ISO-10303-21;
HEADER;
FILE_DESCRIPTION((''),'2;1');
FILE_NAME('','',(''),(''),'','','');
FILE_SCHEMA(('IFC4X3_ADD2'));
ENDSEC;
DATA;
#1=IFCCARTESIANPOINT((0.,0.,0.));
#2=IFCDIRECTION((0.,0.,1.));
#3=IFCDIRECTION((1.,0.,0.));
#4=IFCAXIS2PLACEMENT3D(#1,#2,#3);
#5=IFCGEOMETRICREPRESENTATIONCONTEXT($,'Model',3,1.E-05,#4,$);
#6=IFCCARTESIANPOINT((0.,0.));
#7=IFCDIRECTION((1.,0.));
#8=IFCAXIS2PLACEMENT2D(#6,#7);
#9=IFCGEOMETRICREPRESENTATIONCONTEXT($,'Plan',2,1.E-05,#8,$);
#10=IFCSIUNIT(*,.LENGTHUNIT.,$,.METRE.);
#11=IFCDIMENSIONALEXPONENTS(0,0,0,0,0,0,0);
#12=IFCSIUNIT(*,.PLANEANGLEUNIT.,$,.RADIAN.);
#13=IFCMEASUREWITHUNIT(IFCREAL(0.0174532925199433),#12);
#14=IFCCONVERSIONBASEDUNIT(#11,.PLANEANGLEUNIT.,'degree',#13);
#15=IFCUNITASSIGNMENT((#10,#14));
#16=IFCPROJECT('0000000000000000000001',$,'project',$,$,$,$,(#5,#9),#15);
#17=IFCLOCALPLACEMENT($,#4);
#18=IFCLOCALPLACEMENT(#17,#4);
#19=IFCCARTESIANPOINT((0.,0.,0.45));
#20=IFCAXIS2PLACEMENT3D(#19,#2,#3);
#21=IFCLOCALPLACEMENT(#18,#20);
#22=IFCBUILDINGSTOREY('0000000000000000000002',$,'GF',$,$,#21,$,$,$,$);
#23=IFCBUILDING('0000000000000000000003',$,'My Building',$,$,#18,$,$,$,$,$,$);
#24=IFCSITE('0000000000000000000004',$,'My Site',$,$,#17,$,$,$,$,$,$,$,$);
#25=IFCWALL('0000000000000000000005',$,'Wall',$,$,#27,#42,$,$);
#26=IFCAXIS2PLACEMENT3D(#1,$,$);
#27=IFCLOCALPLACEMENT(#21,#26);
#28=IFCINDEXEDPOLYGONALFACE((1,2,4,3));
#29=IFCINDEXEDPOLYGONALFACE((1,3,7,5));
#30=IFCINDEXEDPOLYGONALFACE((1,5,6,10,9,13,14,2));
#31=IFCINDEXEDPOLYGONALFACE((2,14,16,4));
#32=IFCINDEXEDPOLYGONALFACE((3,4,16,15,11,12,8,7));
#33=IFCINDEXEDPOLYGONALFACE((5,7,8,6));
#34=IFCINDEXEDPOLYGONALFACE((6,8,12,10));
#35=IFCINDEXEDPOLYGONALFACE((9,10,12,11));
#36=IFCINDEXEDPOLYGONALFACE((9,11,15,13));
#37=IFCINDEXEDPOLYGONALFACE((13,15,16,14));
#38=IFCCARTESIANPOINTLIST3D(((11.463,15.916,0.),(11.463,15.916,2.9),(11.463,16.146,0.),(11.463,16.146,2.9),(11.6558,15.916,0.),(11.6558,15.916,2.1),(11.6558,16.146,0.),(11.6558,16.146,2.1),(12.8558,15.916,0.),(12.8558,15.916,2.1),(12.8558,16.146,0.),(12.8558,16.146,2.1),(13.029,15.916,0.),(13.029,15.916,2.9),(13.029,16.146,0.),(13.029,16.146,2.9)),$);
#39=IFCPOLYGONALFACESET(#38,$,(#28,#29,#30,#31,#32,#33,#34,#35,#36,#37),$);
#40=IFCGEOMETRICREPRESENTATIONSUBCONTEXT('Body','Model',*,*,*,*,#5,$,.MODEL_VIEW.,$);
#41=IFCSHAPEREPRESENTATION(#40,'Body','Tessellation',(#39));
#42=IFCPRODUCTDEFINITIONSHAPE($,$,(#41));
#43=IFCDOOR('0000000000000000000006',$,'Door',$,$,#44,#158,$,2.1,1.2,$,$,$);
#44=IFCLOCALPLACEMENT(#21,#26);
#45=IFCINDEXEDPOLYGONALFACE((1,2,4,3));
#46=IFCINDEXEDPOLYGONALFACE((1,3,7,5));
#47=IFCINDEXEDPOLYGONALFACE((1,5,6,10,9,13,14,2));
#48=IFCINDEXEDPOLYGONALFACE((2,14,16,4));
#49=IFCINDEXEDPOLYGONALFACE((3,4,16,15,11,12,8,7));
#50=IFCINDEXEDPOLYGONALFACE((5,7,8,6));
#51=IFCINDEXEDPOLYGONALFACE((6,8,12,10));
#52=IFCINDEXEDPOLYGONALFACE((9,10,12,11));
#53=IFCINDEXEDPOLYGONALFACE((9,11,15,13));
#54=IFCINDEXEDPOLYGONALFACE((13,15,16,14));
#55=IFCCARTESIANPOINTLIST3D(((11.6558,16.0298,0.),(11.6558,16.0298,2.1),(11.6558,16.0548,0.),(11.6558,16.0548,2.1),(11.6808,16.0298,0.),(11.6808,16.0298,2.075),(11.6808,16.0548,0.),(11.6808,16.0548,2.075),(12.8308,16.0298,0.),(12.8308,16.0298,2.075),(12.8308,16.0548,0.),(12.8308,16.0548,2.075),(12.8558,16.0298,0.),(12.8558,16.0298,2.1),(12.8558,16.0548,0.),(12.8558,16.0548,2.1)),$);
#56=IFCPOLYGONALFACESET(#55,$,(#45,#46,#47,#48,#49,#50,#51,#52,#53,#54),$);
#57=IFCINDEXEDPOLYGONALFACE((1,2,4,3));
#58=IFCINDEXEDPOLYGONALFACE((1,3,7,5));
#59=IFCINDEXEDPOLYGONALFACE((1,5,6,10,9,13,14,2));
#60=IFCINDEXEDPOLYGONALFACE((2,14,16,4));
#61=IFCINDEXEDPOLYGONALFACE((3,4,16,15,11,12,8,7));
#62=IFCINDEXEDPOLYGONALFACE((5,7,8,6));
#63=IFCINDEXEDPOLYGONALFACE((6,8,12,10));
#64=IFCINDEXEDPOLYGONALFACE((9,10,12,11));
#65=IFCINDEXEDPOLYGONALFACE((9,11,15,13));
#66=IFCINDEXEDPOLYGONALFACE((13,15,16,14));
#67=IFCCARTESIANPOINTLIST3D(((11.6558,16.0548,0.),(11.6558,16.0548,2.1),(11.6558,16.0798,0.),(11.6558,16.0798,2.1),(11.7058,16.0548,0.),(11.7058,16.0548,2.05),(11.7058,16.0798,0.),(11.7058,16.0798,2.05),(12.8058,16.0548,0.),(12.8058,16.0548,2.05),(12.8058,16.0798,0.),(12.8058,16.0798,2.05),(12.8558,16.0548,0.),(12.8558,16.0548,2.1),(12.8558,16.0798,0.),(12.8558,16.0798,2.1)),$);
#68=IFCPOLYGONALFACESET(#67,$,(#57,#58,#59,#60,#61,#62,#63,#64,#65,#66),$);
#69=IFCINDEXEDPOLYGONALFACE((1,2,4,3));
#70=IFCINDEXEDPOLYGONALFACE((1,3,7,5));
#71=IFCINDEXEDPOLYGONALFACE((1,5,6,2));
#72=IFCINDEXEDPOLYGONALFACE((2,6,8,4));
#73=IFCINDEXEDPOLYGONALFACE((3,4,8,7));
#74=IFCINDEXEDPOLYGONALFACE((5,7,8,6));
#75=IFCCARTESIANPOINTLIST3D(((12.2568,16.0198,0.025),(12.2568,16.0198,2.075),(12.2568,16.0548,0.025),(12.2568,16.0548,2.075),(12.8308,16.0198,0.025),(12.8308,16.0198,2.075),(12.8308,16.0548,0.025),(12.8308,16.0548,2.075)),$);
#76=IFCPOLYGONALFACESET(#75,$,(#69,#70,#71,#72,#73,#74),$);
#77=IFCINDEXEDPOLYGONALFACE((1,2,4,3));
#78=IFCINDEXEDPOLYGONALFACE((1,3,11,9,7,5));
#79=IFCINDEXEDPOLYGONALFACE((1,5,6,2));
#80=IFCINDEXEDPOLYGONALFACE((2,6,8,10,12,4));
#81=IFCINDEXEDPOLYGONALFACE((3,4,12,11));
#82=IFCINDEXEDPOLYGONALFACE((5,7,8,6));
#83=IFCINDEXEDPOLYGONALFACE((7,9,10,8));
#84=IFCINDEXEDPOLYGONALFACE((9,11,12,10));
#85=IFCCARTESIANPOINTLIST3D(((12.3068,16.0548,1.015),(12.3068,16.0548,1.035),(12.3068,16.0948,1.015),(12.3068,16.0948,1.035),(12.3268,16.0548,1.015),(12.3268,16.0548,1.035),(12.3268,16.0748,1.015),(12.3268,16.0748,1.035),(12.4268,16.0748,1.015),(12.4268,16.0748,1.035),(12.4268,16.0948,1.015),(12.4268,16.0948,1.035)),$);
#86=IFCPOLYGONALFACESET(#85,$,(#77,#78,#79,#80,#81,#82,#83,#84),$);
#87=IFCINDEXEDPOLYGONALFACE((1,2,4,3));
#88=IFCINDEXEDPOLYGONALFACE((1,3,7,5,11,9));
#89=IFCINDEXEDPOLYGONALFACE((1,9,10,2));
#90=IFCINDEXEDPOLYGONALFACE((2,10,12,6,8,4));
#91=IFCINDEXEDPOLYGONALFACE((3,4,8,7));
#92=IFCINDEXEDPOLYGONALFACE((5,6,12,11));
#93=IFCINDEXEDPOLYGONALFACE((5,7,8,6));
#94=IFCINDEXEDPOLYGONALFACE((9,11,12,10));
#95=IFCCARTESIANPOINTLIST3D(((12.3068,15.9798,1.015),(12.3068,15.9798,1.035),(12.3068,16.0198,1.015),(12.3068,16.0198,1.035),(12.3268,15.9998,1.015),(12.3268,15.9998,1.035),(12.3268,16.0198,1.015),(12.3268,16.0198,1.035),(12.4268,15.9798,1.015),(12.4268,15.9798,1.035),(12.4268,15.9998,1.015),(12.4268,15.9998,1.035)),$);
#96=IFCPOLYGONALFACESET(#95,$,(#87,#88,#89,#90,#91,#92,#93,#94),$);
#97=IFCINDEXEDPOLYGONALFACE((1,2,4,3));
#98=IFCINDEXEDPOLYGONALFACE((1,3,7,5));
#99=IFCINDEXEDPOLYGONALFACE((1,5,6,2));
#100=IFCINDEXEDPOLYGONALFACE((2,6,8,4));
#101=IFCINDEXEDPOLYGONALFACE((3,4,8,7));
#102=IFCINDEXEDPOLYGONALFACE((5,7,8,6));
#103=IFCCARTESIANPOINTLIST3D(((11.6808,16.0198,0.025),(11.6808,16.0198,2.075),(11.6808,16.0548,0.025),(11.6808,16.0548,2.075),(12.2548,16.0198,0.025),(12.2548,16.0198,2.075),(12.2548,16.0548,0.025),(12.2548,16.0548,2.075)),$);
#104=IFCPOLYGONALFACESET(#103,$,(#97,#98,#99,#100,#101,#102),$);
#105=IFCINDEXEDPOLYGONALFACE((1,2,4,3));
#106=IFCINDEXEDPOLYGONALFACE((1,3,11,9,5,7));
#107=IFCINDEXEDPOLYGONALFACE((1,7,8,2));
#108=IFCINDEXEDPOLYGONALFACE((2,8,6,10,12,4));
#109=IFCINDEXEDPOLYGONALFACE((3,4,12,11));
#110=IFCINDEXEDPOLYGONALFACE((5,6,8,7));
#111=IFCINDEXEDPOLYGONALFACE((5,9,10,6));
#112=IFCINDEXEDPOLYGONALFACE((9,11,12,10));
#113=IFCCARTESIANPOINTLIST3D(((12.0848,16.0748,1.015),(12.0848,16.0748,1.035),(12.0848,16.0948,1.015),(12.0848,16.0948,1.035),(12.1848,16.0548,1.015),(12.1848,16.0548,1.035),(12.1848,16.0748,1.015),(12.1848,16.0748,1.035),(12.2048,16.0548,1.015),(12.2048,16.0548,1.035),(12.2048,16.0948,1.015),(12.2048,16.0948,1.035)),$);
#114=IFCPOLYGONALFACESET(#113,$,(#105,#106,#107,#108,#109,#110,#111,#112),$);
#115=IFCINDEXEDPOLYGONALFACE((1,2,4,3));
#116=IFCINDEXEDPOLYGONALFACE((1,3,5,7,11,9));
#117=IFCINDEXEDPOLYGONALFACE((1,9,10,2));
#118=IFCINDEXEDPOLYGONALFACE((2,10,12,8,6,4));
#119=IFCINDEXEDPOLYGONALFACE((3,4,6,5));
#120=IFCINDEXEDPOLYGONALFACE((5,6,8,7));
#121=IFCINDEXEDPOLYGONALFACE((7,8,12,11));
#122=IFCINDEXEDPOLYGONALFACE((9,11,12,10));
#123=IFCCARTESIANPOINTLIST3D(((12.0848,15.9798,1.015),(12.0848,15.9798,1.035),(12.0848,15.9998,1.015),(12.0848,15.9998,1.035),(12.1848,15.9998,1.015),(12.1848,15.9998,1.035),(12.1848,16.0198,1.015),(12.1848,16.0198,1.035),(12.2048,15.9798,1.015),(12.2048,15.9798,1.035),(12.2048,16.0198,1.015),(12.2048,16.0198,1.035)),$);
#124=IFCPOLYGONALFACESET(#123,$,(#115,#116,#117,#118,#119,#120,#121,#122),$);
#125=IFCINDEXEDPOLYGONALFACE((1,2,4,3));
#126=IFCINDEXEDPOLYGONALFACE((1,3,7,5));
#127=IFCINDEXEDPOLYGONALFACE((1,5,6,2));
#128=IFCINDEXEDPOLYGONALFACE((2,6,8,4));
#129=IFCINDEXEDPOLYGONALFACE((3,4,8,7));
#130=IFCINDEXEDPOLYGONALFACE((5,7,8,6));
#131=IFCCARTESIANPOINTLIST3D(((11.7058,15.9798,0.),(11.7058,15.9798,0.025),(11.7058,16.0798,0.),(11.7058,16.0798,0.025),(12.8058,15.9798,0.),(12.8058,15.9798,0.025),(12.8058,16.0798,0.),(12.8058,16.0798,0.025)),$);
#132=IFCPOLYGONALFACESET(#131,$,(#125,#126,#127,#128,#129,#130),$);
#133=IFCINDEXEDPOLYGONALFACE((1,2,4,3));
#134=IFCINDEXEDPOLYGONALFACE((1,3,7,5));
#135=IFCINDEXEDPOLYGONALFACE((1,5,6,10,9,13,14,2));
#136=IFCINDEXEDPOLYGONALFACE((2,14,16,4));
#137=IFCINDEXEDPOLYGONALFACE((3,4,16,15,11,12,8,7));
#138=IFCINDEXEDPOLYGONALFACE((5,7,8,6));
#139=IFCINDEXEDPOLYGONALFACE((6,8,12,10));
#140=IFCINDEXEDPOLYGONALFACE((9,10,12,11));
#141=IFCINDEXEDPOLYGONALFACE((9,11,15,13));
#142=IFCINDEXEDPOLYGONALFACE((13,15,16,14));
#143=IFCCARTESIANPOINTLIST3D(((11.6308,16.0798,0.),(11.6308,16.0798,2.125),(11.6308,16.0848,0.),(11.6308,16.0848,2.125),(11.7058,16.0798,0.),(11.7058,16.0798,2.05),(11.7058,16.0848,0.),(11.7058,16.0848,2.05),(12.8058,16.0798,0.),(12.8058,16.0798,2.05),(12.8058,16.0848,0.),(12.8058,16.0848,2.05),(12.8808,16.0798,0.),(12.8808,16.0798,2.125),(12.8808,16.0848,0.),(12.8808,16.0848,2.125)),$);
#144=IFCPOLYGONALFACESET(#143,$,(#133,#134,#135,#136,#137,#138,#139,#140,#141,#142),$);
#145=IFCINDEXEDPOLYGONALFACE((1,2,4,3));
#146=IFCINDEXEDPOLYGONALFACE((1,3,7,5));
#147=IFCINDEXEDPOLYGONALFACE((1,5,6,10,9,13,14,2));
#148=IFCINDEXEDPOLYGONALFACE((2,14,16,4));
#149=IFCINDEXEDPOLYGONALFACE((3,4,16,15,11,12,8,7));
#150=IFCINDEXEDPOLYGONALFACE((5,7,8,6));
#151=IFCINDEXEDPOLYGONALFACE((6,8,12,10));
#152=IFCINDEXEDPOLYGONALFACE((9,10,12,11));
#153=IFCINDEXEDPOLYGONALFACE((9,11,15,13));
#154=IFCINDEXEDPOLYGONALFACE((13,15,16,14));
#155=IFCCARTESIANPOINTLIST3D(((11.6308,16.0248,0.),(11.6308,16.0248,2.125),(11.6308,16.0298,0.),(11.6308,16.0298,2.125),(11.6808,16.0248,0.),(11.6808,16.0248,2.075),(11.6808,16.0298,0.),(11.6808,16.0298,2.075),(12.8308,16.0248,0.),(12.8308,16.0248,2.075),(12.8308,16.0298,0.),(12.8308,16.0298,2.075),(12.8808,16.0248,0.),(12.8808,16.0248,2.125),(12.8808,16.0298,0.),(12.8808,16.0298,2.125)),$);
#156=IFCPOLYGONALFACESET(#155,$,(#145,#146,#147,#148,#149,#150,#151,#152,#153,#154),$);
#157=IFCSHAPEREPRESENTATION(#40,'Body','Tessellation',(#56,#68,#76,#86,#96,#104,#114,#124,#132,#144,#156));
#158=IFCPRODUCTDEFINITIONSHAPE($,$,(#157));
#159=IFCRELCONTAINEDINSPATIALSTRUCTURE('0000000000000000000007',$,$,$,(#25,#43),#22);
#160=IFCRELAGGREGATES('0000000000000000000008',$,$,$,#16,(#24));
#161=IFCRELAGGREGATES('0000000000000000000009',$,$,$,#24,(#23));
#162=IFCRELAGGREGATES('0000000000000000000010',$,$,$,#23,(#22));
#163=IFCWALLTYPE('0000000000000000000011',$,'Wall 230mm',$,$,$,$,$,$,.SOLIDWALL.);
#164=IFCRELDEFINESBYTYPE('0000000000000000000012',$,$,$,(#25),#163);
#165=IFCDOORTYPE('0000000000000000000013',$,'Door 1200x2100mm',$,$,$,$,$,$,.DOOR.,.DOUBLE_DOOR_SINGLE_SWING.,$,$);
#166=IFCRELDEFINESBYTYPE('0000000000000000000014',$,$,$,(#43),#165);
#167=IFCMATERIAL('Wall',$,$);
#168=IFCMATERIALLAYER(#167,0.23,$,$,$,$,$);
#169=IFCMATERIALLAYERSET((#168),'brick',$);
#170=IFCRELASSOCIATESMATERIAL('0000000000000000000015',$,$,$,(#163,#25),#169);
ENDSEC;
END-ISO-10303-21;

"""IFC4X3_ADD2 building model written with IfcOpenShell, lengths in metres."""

from ifc_helpers import new_model, entity, si_unit, converted_unit, frame, origin_with_axes, origin_2d_with_axis, place, context, subcontext, project, spatial, line, indexed_curve, outline, extrude, shape, source, transform, mapped, material, layer, layer_set, layer_usage, type_object, type_shapes, element, fill, save


model = new_model("IFC4X3_ADD2")

# Units and contexts
model_context = context("Model", 3, precision=1e-05, world=origin_with_axes())
plan_context = context("Plan", 2, precision=1e-05, world=origin_2d_with_axis())
body_context_1 = subcontext(model_context, "Body", "Model", "MODEL_VIEW")
body_context_2 = subcontext(plan_context, "Body", "Plan", "PLAN_VIEW")
ifc_project = project(units=[si_unit("LENGTHUNIT", "METRE"), converted_unit("PLANEANGLEUNIT", "degree", entity("IfcReal", 0.0174532925199433), si_unit("PLANEANGLEUNIT", "RADIAN"), dimensions=[0, 0, 0, 0, 0, 0, 0])], contexts=[model_context, plan_context])

# Site, building, storey
site_placement = place(None, origin_with_axes())
site = spatial("IfcSite", under=ifc_project, at=site_placement, Name="My Site")
building_placement = place(site_placement, origin_with_axes())
building = spatial("IfcBuilding", under=site, at=building_placement, Name="My Building")
storey_placement = place(building_placement, frame((0.0, 0.0, 0.45), z_axis=(0.0, 0.0, 1.0), x_axis=(1.0, 0.0, 0.0)))
storey = spatial("IfcBuildingStorey", under=building, at=storey_placement, Name="GF")

# Shared definitions
ifc_material_1 = material(Name="Wall")
ifc_layer = layer(ifc_material_1, 0.23)
ifc_layer_set = layer_set([ifc_layer], Name="brick")
wall_type = type_object("IfcWallType", Name="Wall 230mm", PredefinedType="SOLIDWALL", material=ifc_layer_set)

# Shared definitions
shared_shape_1 = source(origin_with_axes(), body_context_1, "Body", "SweptSolid", [
    extrude(outline(indexed_curve([(0.0, 0.0), (1.2, 0.0), (1.2, 2.1), (0.0, 2.1)], segments=[line(1, 2, 3, 4, 1)])), frame((0.0, -0.6, 0.0), z_axis=(0.0, -1.0, 0.0), x_axis=(1.0, 0.0, 0.0)), (0.0, 0.0, -1.0), 1.2),
])
door_type_1 = type_object("IfcDoorType", Name="Door 1200x2100mm", OperationType="DOUBLE_DOOR_SINGLE_SWING", PredefinedType="DOOR")
shared_shape_2 = source(origin_with_axes(), body_context_1, "Body", "SweptSolid", [
    extrude(outline(indexed_curve([(0.0, 0.0), (0.0, 2.1), (1.2, 2.1), (1.2, 0.0), (1.175, 0.0), (1.175, 2.075), (0.025, 2.075), (0.025, 0.0)], segments=[line(1, 2, 3, 4, 5, 6, 7, 8, 1)])), frame((0.0, 0.025, 0.0), z_axis=(0.0, -1.0, 0.0), x_axis=(1.0, 0.0, 0.0)), (0.0, 0.0, -1.0), 0.025),
    extrude(outline(indexed_curve([(0.0, 0.0), (0.0, 2.1), (1.2, 2.1), (1.2, 0.0), (1.15, 0.0), (1.15, 2.05), (0.05, 2.05), (0.05, 0.0)], segments=[line(1, 2, 3, 4, 5, 6, 7, 8, 1)])), frame((0.0, 0.0, 0.0), z_axis=(0.0, -1.0, 0.0), x_axis=(1.0, 0.0, 0.0)), (0.0, 0.0, -1.0), 0.025),
    extrude(outline(indexed_curve([(0.0, 0.0), (0.574, 0.0), (0.574, 0.035), (0.0, 0.035)], segments=[line(1, 2, 3, 4, 1)])), frame((0.025, 0.025, 0.025), z_axis=(0.0, 0.0, 1.0), x_axis=(1.0, 0.0, 0.0)), (0.0, 0.0, 1.0), 2.05),
    extrude(outline(indexed_curve([(0.0, 0.0), (0.0, -0.04), (-0.12, -0.04), (-0.12, -0.02), (-0.02, -0.02), (-0.02, 0.0)], segments=[line(1, 2, 3, 4, 5, 6, 1)])), frame((0.549, 0.025, 1.015), z_axis=(0.0, 0.0, 1.0), x_axis=(1.0, 0.0, 0.0)), (0.0, 0.0, 1.0), 0.02),
    extrude(outline(indexed_curve([(0.0, 0.0), (0.0, 0.04), (-0.12, 0.04), (-0.12, 0.02), (-0.02, 0.02), (-0.02, 0.0)], segments=[line(1, 2, 3, 4, 5, 6, 1)])), frame((0.549, 0.06, 1.015), z_axis=(0.0, 0.0, 1.0), x_axis=(1.0, 0.0, 0.0)), (0.0, 0.0, 1.0), 0.02),
    extrude(outline(indexed_curve([(0.0, 0.0), (-0.574, 0.0), (-0.574, 0.035), (0.0, 0.035)], segments=[line(1, 2, 3, 4, 1)])), frame((1.175, 0.025, 0.025), z_axis=(0.0, 0.0, 1.0), x_axis=(1.0, 0.0, 0.0)), (0.0, 0.0, 1.0), 2.05),
    extrude(outline(indexed_curve([(0.0, 0.0), (0.0, -0.04), (0.12, -0.04), (0.12, -0.02), (0.02, -0.02), (0.02, 0.0)], segments=[line(1, 2, 3, 4, 5, 6, 1)])), frame((0.651, 0.025, 1.015), z_axis=(0.0, 0.0, 1.0), x_axis=(1.0, 0.0, 0.0)), (0.0, 0.0, 1.0), 0.02),
    extrude(outline(indexed_curve([(0.0, 0.0), (0.0, 0.04), (0.12, 0.04), (0.12, 0.02), (0.02, 0.02), (0.02, 0.0)], segments=[line(1, 2, 3, 4, 5, 6, 1)])), frame((0.651, 0.06, 1.015), z_axis=(0.0, 0.0, 1.0), x_axis=(1.0, 0.0, 0.0)), (0.0, 0.0, 1.0), 0.02),
    extrude(outline(indexed_curve([(0.0, 0.0), (1.1, 0.0), (1.1, 0.1), (0.0, 0.1)], segments=[line(1, 2, 3, 4, 1)])), frame((0.05, 0.0, 0.0), z_axis=(0.0, 0.0, 1.0), x_axis=(1.0, 0.0, 0.0)), (0.0, 0.0, 1.0), 0.025),
    extrude(outline(indexed_curve([(0.0, 0.0), (0.0, 2.125), (1.25, 2.125), (1.25, 0.0), (1.175, 0.0), (1.175, 2.05), (0.075, 2.05), (0.075, 0.0)], segments=[line(1, 2, 3, 4, 5, 6, 7, 8, 1)])), frame((-0.025, -0.005, 0.0), z_axis=(0.0, -1.0, 0.0), x_axis=(1.0, 0.0, 0.0)), (0.0, 0.0, -1.0), 0.005),
    extrude(outline(indexed_curve([(0.0, 0.0), (0.0, 2.125), (1.25, 2.125), (1.25, 0.0), (1.2, 0.0), (1.2, 2.075), (0.05, 2.075), (0.05, 0.0)], segments=[line(1, 2, 3, 4, 5, 6, 7, 8, 1)])), frame((-0.025, 0.05, 0.0), z_axis=(0.0, -1.0, 0.0), x_axis=(1.0, 0.0, 0.0)), (0.0, 0.0, -1.0), 0.005),
])
shared_shape_3 = source(origin_with_axes(), body_context_2, "Body", "Curve2D", [
    entity("IfcIndexedPolyCurve", entity("IfcCartesianPointList2D", [[0.0, 0.0], [0.0, 0.05], [0.025, 0.05], [0.025, 0.025], [0.05, 0.025], [0.05, 0.0]]), [entity("IfcLineIndex", [1, 2, 3, 4, 5, 6, 1])]),
    entity("IfcIndexedPolyCurve", entity("IfcCartesianPointList2D", [[1.2, 0.0], [1.2, 0.05], [1.175, 0.05], [1.175, 0.025], [1.15, 0.025], [1.15, 0.0]]), [entity("IfcLineIndex", [1, 2, 3, 4, 5, 6, 1])]),
    entity("IfcTrimmedCurve", entity("IfcEllipse", entity("IfcAxis2Placement2D", entity("IfcCartesianPoint", [0.06, 0.05]), entity("IfcDirection", [1.0, 0.0])), 0.54, 0.575), [entity("IfcCartesianPoint", [0.6, 0.05])], [entity("IfcCartesianPoint", [0.06, 0.625])], True, "CARTESIAN"),
    entity("IfcIndexedPolyCurve", entity("IfcCartesianPointList2D", [[0.025, 0.05], [0.06, 0.05], [0.06, 0.625], [0.025, 0.625]]), [entity("IfcLineIndex", [1, 2, 3, 4, 1])]),
    entity("IfcTrimmedCurve", entity("IfcEllipse", entity("IfcAxis2Placement2D", entity("IfcCartesianPoint", [1.14, 0.05]), entity("IfcDirection", [1.0, 0.0])), 0.54, 0.575), [entity("IfcCartesianPoint", [1.14, 0.625])], [entity("IfcCartesianPoint", [0.6, 0.05])], True, "CARTESIAN"),
    entity("IfcIndexedPolyCurve", entity("IfcCartesianPointList2D", [[1.175, 0.05], [1.14, 0.05], [1.14, 0.625], [1.175, 0.625]]), [entity("IfcLineIndex", [1, 2, 3, 4, 1])]),
])
type_shapes(door_type_1, [shared_shape_2, shared_shape_3])

# Wall, opening, door
ifc_layer_usage_1 = layer_usage(ifc_layer_set, "AXIS2", "POSITIVE", 0.0)
wall_1_placement = place(storey_placement, frame((11.463, 15.916, 0.0), z_axis=(0.0, 0.0, 1.0), x_axis=(1.0, 0.0, 0.0)))
wall_1 = element("IfcWall", 1, at=wall_1_placement, inside=storey, type_object=wall_type, material=ifc_layer_usage_1, Name="Wall", context=body_context_1, shape_type="SweptSolid", body=[
    extrude(outline(indexed_curve([(0.0, 0.0), (0.0, 0.23), (1.566, 0.23), (1.566, 0.0), (0.0, 0.0)], self_intersect=False)), origin_with_axes(), (0.0, 0.0, 1.0), 2.9),
])
opening_1_placement = place(wall_1_placement, frame((1.3928, 0.1638, 0.0), z_axis=(0.0, 0.0, 1.0), x_axis=(-1.0, 0.0, 0.0)))
opening_1 = element("IfcOpeningElement", 2, at=opening_1_placement, cuts=wall_1, PredefinedType="OPENING", context=body_context_1, shape_type="MappedRepresentation", body=[
    mapped(shared_shape_1, transform((0.0, 0.0, 0.0), x_axis=(1.0, 0.0, 0.0), y_axis=(0.0, 1.0, 0.0), z_axis=(0.0, 0.0, 1.0), scale=1.0)),
])
door_1_placement = place(opening_1_placement, origin_with_axes())
door_1 = element("IfcDoor", 3, at=door_1_placement, inside=storey, type_object=door_type_1, Name="Door", OverallHeight=2.1, OverallWidth=1.2, shapes=[
    shape(body_context_1, "Body", "MappedRepresentation", [mapped(shared_shape_2, transform((0.0, 0.0, 0.0), x_axis=(1.0, 0.0, 0.0), y_axis=(0.0, 1.0, 0.0), z_axis=(0.0, 0.0, 1.0), scale=1.0))]),
    shape(body_context_2, "Body", "MappedRepresentation", [mapped(shared_shape_3, transform((0.0, 0.0, 0.0), x_axis=(1.0, 0.0, 0.0), y_axis=(0.0, 1.0, 0.0), z_axis=(0.0, 0.0, 1.0), scale=1.0))]),
])
fill(opening_1, door_1)

save(model, "model.ifc")
